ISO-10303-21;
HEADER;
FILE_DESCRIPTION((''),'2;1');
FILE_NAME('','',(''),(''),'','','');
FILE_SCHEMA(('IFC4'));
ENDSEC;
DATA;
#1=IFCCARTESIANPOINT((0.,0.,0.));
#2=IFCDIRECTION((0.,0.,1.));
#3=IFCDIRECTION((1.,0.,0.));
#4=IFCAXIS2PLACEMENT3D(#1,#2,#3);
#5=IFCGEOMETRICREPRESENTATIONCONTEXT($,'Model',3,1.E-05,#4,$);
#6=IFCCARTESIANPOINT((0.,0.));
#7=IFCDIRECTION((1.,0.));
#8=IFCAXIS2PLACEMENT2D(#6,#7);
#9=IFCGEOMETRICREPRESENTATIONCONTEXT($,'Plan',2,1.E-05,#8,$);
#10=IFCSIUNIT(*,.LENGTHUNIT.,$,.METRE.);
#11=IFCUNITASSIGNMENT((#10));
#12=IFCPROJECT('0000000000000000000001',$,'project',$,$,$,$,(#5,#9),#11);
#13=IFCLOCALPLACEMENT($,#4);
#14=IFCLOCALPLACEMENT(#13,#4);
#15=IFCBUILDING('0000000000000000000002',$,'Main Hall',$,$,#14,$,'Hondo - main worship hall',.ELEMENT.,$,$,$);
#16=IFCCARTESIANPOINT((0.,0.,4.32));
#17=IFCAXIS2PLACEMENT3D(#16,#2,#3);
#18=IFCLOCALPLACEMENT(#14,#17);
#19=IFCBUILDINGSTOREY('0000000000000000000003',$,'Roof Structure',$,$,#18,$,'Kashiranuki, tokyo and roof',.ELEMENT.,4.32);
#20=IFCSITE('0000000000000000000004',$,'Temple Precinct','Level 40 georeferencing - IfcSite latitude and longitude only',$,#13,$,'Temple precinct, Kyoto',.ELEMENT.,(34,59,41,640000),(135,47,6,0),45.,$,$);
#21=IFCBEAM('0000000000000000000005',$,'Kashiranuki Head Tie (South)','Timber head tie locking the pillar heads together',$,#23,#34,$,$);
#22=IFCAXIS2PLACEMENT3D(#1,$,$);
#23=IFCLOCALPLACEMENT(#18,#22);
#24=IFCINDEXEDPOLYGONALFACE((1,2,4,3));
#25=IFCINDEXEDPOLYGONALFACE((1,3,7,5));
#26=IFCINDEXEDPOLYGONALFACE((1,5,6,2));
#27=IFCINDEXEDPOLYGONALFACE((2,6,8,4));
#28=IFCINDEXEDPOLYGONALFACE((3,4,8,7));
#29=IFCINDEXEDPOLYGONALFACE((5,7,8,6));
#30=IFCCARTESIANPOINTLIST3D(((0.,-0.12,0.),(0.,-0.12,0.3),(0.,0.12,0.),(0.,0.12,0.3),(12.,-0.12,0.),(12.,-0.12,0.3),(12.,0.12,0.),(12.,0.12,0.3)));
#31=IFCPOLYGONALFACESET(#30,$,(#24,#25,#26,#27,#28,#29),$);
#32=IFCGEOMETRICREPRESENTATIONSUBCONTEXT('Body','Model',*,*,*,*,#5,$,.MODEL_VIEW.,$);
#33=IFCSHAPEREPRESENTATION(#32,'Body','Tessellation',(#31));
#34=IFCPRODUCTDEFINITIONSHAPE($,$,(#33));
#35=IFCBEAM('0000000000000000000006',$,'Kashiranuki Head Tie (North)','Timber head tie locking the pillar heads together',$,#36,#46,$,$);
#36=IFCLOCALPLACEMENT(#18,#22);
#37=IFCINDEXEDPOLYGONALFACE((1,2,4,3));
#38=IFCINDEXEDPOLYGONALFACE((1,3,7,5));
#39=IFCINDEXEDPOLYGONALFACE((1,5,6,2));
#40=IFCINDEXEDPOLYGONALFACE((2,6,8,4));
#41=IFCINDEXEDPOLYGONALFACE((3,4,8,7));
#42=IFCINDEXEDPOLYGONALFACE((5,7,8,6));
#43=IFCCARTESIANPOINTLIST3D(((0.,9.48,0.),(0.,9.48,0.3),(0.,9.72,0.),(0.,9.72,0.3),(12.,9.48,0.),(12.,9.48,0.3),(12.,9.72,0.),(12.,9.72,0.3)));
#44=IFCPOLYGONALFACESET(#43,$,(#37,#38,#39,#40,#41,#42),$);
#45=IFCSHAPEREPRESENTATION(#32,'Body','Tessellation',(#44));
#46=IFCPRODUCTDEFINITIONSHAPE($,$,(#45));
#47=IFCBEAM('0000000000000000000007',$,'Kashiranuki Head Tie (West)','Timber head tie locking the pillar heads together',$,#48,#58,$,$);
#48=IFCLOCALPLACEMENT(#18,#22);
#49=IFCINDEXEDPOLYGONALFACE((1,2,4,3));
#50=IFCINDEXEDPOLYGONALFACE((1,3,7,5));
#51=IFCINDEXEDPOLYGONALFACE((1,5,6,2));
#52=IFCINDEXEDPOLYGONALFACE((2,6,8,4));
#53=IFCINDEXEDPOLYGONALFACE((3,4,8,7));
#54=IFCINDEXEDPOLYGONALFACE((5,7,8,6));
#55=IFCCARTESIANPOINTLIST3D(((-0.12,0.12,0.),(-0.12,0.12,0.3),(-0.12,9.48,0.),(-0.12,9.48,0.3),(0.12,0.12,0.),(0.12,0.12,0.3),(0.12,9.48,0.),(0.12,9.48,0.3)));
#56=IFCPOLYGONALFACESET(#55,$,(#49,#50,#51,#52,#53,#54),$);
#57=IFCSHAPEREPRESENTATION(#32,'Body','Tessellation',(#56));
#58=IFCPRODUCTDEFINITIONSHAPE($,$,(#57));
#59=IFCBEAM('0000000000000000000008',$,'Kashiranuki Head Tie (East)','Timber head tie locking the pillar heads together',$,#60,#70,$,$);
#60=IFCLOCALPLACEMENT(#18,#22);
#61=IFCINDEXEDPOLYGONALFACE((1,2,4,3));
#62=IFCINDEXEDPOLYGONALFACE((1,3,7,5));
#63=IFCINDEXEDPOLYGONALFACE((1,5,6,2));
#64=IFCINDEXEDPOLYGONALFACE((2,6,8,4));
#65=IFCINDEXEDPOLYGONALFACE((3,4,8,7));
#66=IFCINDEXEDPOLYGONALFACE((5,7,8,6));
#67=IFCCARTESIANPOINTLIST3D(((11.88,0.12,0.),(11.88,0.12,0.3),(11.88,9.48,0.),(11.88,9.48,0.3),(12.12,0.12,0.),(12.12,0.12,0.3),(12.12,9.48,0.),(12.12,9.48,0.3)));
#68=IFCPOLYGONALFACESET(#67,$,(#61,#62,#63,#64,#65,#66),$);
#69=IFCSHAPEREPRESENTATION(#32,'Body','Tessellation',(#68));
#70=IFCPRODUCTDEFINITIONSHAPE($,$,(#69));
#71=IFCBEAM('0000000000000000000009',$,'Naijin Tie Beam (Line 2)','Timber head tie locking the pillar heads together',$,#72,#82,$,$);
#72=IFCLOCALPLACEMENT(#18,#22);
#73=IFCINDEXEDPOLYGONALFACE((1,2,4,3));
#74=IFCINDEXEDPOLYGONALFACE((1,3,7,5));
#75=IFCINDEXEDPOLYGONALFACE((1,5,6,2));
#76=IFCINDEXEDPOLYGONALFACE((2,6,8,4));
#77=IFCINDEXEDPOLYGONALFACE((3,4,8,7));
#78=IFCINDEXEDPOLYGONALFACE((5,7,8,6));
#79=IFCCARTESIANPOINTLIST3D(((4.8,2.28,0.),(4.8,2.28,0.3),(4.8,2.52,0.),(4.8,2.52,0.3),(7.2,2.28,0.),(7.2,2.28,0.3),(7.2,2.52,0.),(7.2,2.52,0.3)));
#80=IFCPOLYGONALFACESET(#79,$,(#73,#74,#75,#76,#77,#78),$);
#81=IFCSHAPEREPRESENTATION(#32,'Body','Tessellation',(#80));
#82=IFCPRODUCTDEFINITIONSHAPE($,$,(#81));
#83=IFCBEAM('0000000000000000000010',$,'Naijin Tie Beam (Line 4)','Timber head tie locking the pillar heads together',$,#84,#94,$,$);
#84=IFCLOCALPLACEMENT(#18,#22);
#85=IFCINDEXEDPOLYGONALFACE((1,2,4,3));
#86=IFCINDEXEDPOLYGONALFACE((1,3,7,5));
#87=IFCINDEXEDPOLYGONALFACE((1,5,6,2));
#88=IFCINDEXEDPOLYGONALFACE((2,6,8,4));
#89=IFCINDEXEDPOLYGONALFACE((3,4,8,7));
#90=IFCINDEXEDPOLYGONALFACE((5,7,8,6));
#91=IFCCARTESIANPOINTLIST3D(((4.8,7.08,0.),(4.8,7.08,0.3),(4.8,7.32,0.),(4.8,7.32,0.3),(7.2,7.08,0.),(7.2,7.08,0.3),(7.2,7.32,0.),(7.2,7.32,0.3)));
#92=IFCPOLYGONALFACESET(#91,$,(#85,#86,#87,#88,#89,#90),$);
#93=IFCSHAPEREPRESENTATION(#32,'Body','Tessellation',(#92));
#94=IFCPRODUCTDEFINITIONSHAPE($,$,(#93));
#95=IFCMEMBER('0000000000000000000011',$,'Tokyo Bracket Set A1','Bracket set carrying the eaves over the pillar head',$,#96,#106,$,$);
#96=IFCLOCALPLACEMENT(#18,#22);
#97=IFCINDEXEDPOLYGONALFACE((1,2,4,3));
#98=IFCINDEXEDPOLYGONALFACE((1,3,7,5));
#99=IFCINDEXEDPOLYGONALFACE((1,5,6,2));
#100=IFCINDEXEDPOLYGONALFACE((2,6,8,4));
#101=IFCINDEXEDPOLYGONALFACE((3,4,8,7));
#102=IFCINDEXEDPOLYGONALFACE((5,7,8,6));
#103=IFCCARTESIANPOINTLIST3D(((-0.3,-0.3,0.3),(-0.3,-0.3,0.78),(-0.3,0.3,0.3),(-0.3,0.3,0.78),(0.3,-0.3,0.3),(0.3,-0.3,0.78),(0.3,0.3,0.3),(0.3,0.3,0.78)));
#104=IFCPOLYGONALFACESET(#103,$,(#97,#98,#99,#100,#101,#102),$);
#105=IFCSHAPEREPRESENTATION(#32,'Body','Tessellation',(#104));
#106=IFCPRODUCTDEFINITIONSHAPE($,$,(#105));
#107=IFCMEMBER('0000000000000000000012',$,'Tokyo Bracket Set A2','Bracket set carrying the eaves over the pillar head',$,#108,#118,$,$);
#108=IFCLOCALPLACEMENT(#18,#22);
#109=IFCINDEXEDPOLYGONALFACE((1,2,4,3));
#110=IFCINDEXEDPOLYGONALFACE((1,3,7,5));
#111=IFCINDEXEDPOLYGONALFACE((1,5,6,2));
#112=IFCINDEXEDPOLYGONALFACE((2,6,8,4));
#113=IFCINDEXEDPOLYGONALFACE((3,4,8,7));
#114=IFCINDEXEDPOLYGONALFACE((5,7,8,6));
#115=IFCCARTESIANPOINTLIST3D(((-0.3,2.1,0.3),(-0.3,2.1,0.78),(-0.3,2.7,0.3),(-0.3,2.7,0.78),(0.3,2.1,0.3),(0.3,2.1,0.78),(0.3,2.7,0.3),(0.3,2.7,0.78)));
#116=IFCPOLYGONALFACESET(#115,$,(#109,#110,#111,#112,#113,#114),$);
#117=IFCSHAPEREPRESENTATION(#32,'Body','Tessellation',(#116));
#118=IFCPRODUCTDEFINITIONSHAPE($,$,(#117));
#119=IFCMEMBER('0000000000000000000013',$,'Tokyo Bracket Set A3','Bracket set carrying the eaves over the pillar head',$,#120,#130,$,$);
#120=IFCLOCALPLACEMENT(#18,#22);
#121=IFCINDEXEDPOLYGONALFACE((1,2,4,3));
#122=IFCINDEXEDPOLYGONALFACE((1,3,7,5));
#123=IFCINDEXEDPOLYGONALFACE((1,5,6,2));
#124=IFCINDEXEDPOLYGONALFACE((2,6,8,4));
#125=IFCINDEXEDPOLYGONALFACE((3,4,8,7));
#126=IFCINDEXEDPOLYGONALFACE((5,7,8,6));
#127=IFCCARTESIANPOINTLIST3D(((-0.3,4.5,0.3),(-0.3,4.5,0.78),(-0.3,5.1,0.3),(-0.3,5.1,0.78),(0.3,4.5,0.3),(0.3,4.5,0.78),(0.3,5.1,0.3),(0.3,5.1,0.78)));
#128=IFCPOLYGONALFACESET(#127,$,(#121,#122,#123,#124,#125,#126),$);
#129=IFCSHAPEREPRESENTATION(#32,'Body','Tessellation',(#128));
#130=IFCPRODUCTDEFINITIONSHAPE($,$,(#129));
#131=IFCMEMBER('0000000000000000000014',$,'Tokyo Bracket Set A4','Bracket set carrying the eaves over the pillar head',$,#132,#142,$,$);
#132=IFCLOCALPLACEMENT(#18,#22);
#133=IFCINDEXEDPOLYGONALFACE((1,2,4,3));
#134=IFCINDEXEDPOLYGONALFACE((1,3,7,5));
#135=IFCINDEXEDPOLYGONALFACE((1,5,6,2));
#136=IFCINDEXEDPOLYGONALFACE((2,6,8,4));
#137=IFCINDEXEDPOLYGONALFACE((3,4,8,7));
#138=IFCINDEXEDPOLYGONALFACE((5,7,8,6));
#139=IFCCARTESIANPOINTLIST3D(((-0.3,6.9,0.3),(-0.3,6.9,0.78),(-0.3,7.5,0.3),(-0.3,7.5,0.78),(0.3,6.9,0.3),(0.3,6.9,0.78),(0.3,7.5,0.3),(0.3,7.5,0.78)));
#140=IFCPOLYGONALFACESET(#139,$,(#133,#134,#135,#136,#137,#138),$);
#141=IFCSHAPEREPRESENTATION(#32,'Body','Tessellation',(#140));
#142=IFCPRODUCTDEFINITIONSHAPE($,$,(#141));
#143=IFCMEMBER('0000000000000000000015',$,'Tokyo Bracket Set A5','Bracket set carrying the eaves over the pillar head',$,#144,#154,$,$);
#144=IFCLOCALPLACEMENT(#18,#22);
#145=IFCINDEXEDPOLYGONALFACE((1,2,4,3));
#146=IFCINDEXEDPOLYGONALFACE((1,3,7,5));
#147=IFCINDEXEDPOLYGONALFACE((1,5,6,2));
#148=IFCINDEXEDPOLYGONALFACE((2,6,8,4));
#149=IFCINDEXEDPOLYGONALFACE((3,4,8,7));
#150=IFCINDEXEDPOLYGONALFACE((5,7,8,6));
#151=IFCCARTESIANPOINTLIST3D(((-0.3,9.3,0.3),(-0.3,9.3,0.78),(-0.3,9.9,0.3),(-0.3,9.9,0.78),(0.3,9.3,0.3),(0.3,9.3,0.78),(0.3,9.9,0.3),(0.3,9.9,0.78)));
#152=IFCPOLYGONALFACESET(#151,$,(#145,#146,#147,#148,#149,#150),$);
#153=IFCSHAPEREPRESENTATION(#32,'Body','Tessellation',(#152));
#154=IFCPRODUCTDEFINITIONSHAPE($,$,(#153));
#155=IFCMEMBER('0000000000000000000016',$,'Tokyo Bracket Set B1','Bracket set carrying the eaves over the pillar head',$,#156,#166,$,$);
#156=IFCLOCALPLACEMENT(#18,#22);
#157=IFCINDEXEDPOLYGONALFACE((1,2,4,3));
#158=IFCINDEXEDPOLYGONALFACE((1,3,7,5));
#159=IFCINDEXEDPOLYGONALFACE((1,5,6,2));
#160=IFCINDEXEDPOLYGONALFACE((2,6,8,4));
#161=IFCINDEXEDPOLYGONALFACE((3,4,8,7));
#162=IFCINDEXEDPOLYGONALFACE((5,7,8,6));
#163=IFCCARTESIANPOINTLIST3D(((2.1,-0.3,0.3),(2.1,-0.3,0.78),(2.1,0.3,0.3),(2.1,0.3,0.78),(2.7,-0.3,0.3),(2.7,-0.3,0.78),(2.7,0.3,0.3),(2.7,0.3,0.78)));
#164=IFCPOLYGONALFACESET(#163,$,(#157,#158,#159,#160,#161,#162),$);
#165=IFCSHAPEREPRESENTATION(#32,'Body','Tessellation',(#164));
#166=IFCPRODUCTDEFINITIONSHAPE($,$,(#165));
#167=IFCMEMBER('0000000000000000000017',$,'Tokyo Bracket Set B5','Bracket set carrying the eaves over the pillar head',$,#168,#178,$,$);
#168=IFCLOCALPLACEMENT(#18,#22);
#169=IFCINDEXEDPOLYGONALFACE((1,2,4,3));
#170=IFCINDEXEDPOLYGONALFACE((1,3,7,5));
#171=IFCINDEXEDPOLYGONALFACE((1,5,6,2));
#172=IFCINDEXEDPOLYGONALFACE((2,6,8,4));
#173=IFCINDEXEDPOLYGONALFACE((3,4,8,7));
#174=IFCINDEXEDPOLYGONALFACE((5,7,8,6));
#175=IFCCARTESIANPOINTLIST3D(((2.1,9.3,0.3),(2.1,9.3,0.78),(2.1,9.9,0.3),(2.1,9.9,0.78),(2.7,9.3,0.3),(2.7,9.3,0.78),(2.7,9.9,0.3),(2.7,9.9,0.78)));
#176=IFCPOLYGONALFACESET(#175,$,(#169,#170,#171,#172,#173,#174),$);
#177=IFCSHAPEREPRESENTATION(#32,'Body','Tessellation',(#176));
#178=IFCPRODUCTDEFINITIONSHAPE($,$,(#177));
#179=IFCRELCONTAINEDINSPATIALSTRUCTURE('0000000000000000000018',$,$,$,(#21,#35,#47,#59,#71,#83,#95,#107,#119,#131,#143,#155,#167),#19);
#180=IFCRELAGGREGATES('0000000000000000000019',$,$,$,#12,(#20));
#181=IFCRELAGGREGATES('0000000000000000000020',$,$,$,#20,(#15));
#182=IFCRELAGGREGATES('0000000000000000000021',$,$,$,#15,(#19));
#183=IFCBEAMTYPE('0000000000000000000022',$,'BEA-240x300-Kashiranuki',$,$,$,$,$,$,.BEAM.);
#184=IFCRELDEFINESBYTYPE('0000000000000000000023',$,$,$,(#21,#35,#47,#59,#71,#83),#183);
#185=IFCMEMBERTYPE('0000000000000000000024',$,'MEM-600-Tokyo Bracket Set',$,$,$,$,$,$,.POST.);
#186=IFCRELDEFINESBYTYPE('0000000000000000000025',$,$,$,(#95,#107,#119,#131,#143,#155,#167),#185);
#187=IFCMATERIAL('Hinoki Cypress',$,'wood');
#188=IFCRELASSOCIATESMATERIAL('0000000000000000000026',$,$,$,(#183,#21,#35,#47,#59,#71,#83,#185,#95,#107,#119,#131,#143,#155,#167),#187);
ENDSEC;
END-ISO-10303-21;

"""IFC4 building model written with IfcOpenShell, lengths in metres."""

from ifc_helpers import new_model, si_unit, frame, origin_with_axes, origin_2d_with_axis, place, context, subcontext, project, spatial, line, indexed_curve, rectangle, outline, extrude, material, material_profile, profile_set, profile_usage, type_object, element, save


model = new_model("IFC4")

# Units and contexts
model_context = context("Model", 3, precision=1e-05, world=origin_with_axes())
plan_context = context("Plan", 2, precision=1e-05, world=origin_2d_with_axis())
body_context = subcontext(model_context, "Body", "Model", "MODEL_VIEW")
ifc_project = project(units=[si_unit("LENGTHUNIT", "METRE")], contexts=[model_context, plan_context])

# Site, building, storey
site_placement = place(None, origin_with_axes())
site = spatial("IfcSite", under=ifc_project, at=site_placement, Name="Temple Precinct", Description="Level 40 georeferencing - IfcSite latitude and longitude only", LongName="Temple precinct, Kyoto", CompositionType="ELEMENT", RefLatitude=(34, 59, 41, 640000), RefLongitude=(135, 47, 6, 0), RefElevation=45.0)
building_placement = place(site_placement, origin_with_axes())
building = spatial("IfcBuilding", under=site, at=building_placement, Name="Main Hall", LongName="Hondo - main worship hall", CompositionType="ELEMENT")
storey_placement = place(building_placement, frame((0.0, 0.0, 4.32), z_axis=(0.0, 0.0, 1.0), x_axis=(1.0, 0.0, 0.0)))
storey = spatial("IfcBuildingStorey", under=building, at=storey_placement, Name="Roof Structure", LongName="Kashiranuki, tokyo and roof", CompositionType="ELEMENT", Elevation=4.32)

# Beams
ifc_material_1 = material(Name="Hinoki Cypress", Category="wood")
ifc_material_profile_1 = material_profile(ifc_material_1, rectangle(XDim=0.24, YDim=0.3))
ifc_profile_set_1 = profile_set([ifc_material_profile_1], Name="BEA-240x300-Kashiranuki")
ifc_profile_usage_1 = profile_usage(ifc_profile_set_1)
beam_type = type_object("IfcBeamType", Name="BEA-240x300-Kashiranuki", PredefinedType="BEAM", material=ifc_profile_set_1)
beam_1_placement = place(storey_placement, frame((0.0, -0.12, 0.0), z_axis=(1.0, 0.0, 0.0), x_axis=(0.0, 1.0, 0.0)))
element("IfcBeam", 1, at=beam_1_placement, inside=storey, type_object=beam_type, material=ifc_profile_usage_1, Name="Kashiranuki Head Tie (South)", Description="Timber head tie locking the pillar heads together", context=body_context, shape_type="SweptSolid", body=[
    extrude(outline(indexed_curve([(0.0, 0.0), (0.24, 0.0), (0.24, 0.3), (0.0, 0.3)], segments=[line(1, 2, 3, 4, 1)])), origin_with_axes(), (0.0, 0.0, 1.0), 12.0),
])
ifc_profile_usage_2 = profile_usage(ifc_profile_set_1)
beam_2_placement = place(storey_placement, frame((0.0, 9.48, 0.0), z_axis=(1.0, 0.0, 0.0), x_axis=(0.0, 1.0, 0.0)))
element("IfcBeam", 2, at=beam_2_placement, inside=storey, type_object=beam_type, material=ifc_profile_usage_2, Name="Kashiranuki Head Tie (North)", Description="Timber head tie locking the pillar heads together", context=body_context, shape_type="SweptSolid", body=[
    extrude(outline(indexed_curve([(0.0, 0.0), (0.24, 0.0), (0.24, 0.3), (0.0, 0.3)], segments=[line(1, 2, 3, 4, 1)])), origin_with_axes(), (0.0, 0.0, 1.0), 12.0),
])
ifc_profile_usage_3 = profile_usage(ifc_profile_set_1)
beam_3_placement = place(storey_placement, frame((-0.12, 0.12, 0.0), z_axis=(0.0, 1.0, 0.0), x_axis=(0.0, 0.0, 1.0)))
element("IfcBeam", 3, at=beam_3_placement, inside=storey, type_object=beam_type, material=ifc_profile_usage_3, Name="Kashiranuki Head Tie (West)", Description="Timber head tie locking the pillar heads together", context=body_context, shape_type="SweptSolid", body=[
    extrude(outline(indexed_curve([(0.0, 0.0), (0.3, 0.0), (0.3, 0.24), (0.0, 0.24)], segments=[line(1, 2, 3, 4, 1)])), origin_with_axes(), (0.0, 0.0, 1.0), 9.36),
])
ifc_profile_usage_4 = profile_usage(ifc_profile_set_1)
beam_4_placement = place(storey_placement, frame((11.88, 0.12, 0.0), z_axis=(0.0, 1.0, 0.0), x_axis=(0.0, 0.0, 1.0)))
element("IfcBeam", 4, at=beam_4_placement, inside=storey, type_object=beam_type, material=ifc_profile_usage_4, Name="Kashiranuki Head Tie (East)", Description="Timber head tie locking the pillar heads together", context=body_context, shape_type="SweptSolid", body=[
    extrude(outline(indexed_curve([(0.0, 0.0), (0.3, 0.0), (0.3, 0.24), (0.0, 0.24)], segments=[line(1, 2, 3, 4, 1)])), origin_with_axes(), (0.0, 0.0, 1.0), 9.36),
])
ifc_profile_usage_5 = profile_usage(ifc_profile_set_1)
beam_5_placement = place(storey_placement, frame((4.8, 2.28, 0.0), z_axis=(1.0, 0.0, 0.0), x_axis=(0.0, 1.0, 0.0)))
element("IfcBeam", 5, at=beam_5_placement, inside=storey, type_object=beam_type, material=ifc_profile_usage_5, Name="Naijin Tie Beam (Line 2)", Description="Timber head tie locking the pillar heads together", context=body_context, shape_type="SweptSolid", body=[
    extrude(outline(indexed_curve([(0.0, 0.0), (0.24, 0.0), (0.24, 0.3), (0.0, 0.3)], segments=[line(1, 2, 3, 4, 1)])), origin_with_axes(), (0.0, 0.0, 1.0), 2.4),
])
ifc_profile_usage_6 = profile_usage(ifc_profile_set_1)
beam_6_placement = place(storey_placement, frame((4.8, 7.08, 0.0), z_axis=(1.0, 0.0, 0.0), x_axis=(0.0, 1.0, 0.0)))
element("IfcBeam", 6, at=beam_6_placement, inside=storey, type_object=beam_type, material=ifc_profile_usage_6, Name="Naijin Tie Beam (Line 4)", Description="Timber head tie locking the pillar heads together", context=body_context, shape_type="SweptSolid", body=[
    extrude(outline(indexed_curve([(0.0, 0.0), (0.24, 0.0), (0.24, 0.3), (0.0, 0.3)], segments=[line(1, 2, 3, 4, 1)])), origin_with_axes(), (0.0, 0.0, 1.0), 2.4),
])

# Members
ifc_material_profile_2 = material_profile(ifc_material_1, rectangle(XDim=0.6, YDim=0.6))
ifc_profile_set_2 = profile_set([ifc_material_profile_2], Name="MEM-600-Tokyo Bracket Set")
ifc_profile_usage_7 = profile_usage(ifc_profile_set_2)
member_type = type_object("IfcMemberType", Name="MEM-600-Tokyo Bracket Set", PredefinedType="POST", material=ifc_profile_set_2)
member_1_placement = place(storey_placement, frame((-0.3, -0.3, 0.3), z_axis=(0.0, 0.0, 1.0), x_axis=(1.0, 0.0, 0.0)))
element("IfcMember", 7, at=member_1_placement, inside=storey, type_object=member_type, material=ifc_profile_usage_7, Name="Tokyo Bracket Set A1", Description="Bracket set carrying the eaves over the pillar head", context=body_context, shape_type="SweptSolid", body=[
    extrude(outline(indexed_curve([(0.0, 0.0), (0.6, 0.0), (0.6, 0.6), (0.0, 0.6)], segments=[line(1, 2, 3, 4, 1)])), origin_with_axes(), (0.0, 0.0, 1.0), 0.48),
])
ifc_profile_usage_8 = profile_usage(ifc_profile_set_2)
member_2_placement = place(storey_placement, frame((-0.3, 2.1, 0.3), z_axis=(0.0, 0.0, 1.0), x_axis=(1.0, 0.0, 0.0)))
element("IfcMember", 8, at=member_2_placement, inside=storey, type_object=member_type, material=ifc_profile_usage_8, Name="Tokyo Bracket Set A2", Description="Bracket set carrying the eaves over the pillar head", context=body_context, shape_type="SweptSolid", body=[
    extrude(outline(indexed_curve([(0.0, 0.0), (0.6, 0.0), (0.6, 0.6), (0.0, 0.6)], segments=[line(1, 2, 3, 4, 1)])), origin_with_axes(), (0.0, 0.0, 1.0), 0.48),
])
ifc_profile_usage_9 = profile_usage(ifc_profile_set_2)
member_3_placement = place(storey_placement, frame((-0.3, 4.5, 0.3), z_axis=(0.0, 0.0, 1.0), x_axis=(1.0, 0.0, 0.0)))
element("IfcMember", 9, at=member_3_placement, inside=storey, type_object=member_type, material=ifc_profile_usage_9, Name="Tokyo Bracket Set A3", Description="Bracket set carrying the eaves over the pillar head", context=body_context, shape_type="SweptSolid", body=[
    extrude(outline(indexed_curve([(0.0, 0.0), (0.6, 0.0), (0.6, 0.6), (0.0, 0.6)], segments=[line(1, 2, 3, 4, 1)])), origin_with_axes(), (0.0, 0.0, 1.0), 0.48),
])
ifc_profile_usage_10 = profile_usage(ifc_profile_set_2)
member_4_placement = place(storey_placement, frame((-0.3, 6.9, 0.3), z_axis=(0.0, 0.0, 1.0), x_axis=(1.0, 0.0, 0.0)))
element("IfcMember", 10, at=member_4_placement, inside=storey, type_object=member_type, material=ifc_profile_usage_10, Name="Tokyo Bracket Set A4", Description="Bracket set carrying the eaves over the pillar head", context=body_context, shape_type="SweptSolid", body=[
    extrude(outline(indexed_curve([(0.0, 0.0), (0.6, 0.0), (0.6, 0.6), (0.0, 0.6)], segments=[line(1, 2, 3, 4, 1)])), origin_with_axes(), (0.0, 0.0, 1.0), 0.48),
])
ifc_profile_usage_11 = profile_usage(ifc_profile_set_2)
member_5_placement = place(storey_placement, frame((-0.3, 9.3, 0.3), z_axis=(0.0, 0.0, 1.0), x_axis=(1.0, 0.0, 0.0)))
element("IfcMember", 11, at=member_5_placement, inside=storey, type_object=member_type, material=ifc_profile_usage_11, Name="Tokyo Bracket Set A5", Description="Bracket set carrying the eaves over the pillar head", context=body_context, shape_type="SweptSolid", body=[
    extrude(outline(indexed_curve([(0.0, 0.0), (0.6, 0.0), (0.6, 0.6), (0.0, 0.6)], segments=[line(1, 2, 3, 4, 1)])), origin_with_axes(), (0.0, 0.0, 1.0), 0.48),
])
ifc_profile_usage_12 = profile_usage(ifc_profile_set_2)
member_6_placement = place(storey_placement, frame((2.1, -0.3, 0.3), z_axis=(0.0, 0.0, 1.0), x_axis=(1.0, 0.0, 0.0)))
element("IfcMember", 12, at=member_6_placement, inside=storey, type_object=member_type, material=ifc_profile_usage_12, Name="Tokyo Bracket Set B1", Description="Bracket set carrying the eaves over the pillar head", context=body_context, shape_type="SweptSolid", body=[
    extrude(outline(indexed_curve([(0.0, 0.0), (0.6, 0.0), (0.6, 0.6), (0.0, 0.6)], segments=[line(1, 2, 3, 4, 1)])), origin_with_axes(), (0.0, 0.0, 1.0), 0.48),
])
ifc_profile_usage_13 = profile_usage(ifc_profile_set_2)
member_7_placement = place(storey_placement, frame((2.1, 9.3, 0.3), z_axis=(0.0, 0.0, 1.0), x_axis=(1.0, 0.0, 0.0)))
element("IfcMember", 13, at=member_7_placement, inside=storey, type_object=member_type, material=ifc_profile_usage_13, Name="Tokyo Bracket Set B5", Description="Bracket set carrying the eaves over the pillar head", context=body_context, shape_type="SweptSolid", body=[
    extrude(outline(indexed_curve([(0.0, 0.0), (0.6, 0.0), (0.6, 0.6), (0.0, 0.6)], segments=[line(1, 2, 3, 4, 1)])), origin_with_axes(), (0.0, 0.0, 1.0), 0.48),
])

save(model, "model.ifc")
